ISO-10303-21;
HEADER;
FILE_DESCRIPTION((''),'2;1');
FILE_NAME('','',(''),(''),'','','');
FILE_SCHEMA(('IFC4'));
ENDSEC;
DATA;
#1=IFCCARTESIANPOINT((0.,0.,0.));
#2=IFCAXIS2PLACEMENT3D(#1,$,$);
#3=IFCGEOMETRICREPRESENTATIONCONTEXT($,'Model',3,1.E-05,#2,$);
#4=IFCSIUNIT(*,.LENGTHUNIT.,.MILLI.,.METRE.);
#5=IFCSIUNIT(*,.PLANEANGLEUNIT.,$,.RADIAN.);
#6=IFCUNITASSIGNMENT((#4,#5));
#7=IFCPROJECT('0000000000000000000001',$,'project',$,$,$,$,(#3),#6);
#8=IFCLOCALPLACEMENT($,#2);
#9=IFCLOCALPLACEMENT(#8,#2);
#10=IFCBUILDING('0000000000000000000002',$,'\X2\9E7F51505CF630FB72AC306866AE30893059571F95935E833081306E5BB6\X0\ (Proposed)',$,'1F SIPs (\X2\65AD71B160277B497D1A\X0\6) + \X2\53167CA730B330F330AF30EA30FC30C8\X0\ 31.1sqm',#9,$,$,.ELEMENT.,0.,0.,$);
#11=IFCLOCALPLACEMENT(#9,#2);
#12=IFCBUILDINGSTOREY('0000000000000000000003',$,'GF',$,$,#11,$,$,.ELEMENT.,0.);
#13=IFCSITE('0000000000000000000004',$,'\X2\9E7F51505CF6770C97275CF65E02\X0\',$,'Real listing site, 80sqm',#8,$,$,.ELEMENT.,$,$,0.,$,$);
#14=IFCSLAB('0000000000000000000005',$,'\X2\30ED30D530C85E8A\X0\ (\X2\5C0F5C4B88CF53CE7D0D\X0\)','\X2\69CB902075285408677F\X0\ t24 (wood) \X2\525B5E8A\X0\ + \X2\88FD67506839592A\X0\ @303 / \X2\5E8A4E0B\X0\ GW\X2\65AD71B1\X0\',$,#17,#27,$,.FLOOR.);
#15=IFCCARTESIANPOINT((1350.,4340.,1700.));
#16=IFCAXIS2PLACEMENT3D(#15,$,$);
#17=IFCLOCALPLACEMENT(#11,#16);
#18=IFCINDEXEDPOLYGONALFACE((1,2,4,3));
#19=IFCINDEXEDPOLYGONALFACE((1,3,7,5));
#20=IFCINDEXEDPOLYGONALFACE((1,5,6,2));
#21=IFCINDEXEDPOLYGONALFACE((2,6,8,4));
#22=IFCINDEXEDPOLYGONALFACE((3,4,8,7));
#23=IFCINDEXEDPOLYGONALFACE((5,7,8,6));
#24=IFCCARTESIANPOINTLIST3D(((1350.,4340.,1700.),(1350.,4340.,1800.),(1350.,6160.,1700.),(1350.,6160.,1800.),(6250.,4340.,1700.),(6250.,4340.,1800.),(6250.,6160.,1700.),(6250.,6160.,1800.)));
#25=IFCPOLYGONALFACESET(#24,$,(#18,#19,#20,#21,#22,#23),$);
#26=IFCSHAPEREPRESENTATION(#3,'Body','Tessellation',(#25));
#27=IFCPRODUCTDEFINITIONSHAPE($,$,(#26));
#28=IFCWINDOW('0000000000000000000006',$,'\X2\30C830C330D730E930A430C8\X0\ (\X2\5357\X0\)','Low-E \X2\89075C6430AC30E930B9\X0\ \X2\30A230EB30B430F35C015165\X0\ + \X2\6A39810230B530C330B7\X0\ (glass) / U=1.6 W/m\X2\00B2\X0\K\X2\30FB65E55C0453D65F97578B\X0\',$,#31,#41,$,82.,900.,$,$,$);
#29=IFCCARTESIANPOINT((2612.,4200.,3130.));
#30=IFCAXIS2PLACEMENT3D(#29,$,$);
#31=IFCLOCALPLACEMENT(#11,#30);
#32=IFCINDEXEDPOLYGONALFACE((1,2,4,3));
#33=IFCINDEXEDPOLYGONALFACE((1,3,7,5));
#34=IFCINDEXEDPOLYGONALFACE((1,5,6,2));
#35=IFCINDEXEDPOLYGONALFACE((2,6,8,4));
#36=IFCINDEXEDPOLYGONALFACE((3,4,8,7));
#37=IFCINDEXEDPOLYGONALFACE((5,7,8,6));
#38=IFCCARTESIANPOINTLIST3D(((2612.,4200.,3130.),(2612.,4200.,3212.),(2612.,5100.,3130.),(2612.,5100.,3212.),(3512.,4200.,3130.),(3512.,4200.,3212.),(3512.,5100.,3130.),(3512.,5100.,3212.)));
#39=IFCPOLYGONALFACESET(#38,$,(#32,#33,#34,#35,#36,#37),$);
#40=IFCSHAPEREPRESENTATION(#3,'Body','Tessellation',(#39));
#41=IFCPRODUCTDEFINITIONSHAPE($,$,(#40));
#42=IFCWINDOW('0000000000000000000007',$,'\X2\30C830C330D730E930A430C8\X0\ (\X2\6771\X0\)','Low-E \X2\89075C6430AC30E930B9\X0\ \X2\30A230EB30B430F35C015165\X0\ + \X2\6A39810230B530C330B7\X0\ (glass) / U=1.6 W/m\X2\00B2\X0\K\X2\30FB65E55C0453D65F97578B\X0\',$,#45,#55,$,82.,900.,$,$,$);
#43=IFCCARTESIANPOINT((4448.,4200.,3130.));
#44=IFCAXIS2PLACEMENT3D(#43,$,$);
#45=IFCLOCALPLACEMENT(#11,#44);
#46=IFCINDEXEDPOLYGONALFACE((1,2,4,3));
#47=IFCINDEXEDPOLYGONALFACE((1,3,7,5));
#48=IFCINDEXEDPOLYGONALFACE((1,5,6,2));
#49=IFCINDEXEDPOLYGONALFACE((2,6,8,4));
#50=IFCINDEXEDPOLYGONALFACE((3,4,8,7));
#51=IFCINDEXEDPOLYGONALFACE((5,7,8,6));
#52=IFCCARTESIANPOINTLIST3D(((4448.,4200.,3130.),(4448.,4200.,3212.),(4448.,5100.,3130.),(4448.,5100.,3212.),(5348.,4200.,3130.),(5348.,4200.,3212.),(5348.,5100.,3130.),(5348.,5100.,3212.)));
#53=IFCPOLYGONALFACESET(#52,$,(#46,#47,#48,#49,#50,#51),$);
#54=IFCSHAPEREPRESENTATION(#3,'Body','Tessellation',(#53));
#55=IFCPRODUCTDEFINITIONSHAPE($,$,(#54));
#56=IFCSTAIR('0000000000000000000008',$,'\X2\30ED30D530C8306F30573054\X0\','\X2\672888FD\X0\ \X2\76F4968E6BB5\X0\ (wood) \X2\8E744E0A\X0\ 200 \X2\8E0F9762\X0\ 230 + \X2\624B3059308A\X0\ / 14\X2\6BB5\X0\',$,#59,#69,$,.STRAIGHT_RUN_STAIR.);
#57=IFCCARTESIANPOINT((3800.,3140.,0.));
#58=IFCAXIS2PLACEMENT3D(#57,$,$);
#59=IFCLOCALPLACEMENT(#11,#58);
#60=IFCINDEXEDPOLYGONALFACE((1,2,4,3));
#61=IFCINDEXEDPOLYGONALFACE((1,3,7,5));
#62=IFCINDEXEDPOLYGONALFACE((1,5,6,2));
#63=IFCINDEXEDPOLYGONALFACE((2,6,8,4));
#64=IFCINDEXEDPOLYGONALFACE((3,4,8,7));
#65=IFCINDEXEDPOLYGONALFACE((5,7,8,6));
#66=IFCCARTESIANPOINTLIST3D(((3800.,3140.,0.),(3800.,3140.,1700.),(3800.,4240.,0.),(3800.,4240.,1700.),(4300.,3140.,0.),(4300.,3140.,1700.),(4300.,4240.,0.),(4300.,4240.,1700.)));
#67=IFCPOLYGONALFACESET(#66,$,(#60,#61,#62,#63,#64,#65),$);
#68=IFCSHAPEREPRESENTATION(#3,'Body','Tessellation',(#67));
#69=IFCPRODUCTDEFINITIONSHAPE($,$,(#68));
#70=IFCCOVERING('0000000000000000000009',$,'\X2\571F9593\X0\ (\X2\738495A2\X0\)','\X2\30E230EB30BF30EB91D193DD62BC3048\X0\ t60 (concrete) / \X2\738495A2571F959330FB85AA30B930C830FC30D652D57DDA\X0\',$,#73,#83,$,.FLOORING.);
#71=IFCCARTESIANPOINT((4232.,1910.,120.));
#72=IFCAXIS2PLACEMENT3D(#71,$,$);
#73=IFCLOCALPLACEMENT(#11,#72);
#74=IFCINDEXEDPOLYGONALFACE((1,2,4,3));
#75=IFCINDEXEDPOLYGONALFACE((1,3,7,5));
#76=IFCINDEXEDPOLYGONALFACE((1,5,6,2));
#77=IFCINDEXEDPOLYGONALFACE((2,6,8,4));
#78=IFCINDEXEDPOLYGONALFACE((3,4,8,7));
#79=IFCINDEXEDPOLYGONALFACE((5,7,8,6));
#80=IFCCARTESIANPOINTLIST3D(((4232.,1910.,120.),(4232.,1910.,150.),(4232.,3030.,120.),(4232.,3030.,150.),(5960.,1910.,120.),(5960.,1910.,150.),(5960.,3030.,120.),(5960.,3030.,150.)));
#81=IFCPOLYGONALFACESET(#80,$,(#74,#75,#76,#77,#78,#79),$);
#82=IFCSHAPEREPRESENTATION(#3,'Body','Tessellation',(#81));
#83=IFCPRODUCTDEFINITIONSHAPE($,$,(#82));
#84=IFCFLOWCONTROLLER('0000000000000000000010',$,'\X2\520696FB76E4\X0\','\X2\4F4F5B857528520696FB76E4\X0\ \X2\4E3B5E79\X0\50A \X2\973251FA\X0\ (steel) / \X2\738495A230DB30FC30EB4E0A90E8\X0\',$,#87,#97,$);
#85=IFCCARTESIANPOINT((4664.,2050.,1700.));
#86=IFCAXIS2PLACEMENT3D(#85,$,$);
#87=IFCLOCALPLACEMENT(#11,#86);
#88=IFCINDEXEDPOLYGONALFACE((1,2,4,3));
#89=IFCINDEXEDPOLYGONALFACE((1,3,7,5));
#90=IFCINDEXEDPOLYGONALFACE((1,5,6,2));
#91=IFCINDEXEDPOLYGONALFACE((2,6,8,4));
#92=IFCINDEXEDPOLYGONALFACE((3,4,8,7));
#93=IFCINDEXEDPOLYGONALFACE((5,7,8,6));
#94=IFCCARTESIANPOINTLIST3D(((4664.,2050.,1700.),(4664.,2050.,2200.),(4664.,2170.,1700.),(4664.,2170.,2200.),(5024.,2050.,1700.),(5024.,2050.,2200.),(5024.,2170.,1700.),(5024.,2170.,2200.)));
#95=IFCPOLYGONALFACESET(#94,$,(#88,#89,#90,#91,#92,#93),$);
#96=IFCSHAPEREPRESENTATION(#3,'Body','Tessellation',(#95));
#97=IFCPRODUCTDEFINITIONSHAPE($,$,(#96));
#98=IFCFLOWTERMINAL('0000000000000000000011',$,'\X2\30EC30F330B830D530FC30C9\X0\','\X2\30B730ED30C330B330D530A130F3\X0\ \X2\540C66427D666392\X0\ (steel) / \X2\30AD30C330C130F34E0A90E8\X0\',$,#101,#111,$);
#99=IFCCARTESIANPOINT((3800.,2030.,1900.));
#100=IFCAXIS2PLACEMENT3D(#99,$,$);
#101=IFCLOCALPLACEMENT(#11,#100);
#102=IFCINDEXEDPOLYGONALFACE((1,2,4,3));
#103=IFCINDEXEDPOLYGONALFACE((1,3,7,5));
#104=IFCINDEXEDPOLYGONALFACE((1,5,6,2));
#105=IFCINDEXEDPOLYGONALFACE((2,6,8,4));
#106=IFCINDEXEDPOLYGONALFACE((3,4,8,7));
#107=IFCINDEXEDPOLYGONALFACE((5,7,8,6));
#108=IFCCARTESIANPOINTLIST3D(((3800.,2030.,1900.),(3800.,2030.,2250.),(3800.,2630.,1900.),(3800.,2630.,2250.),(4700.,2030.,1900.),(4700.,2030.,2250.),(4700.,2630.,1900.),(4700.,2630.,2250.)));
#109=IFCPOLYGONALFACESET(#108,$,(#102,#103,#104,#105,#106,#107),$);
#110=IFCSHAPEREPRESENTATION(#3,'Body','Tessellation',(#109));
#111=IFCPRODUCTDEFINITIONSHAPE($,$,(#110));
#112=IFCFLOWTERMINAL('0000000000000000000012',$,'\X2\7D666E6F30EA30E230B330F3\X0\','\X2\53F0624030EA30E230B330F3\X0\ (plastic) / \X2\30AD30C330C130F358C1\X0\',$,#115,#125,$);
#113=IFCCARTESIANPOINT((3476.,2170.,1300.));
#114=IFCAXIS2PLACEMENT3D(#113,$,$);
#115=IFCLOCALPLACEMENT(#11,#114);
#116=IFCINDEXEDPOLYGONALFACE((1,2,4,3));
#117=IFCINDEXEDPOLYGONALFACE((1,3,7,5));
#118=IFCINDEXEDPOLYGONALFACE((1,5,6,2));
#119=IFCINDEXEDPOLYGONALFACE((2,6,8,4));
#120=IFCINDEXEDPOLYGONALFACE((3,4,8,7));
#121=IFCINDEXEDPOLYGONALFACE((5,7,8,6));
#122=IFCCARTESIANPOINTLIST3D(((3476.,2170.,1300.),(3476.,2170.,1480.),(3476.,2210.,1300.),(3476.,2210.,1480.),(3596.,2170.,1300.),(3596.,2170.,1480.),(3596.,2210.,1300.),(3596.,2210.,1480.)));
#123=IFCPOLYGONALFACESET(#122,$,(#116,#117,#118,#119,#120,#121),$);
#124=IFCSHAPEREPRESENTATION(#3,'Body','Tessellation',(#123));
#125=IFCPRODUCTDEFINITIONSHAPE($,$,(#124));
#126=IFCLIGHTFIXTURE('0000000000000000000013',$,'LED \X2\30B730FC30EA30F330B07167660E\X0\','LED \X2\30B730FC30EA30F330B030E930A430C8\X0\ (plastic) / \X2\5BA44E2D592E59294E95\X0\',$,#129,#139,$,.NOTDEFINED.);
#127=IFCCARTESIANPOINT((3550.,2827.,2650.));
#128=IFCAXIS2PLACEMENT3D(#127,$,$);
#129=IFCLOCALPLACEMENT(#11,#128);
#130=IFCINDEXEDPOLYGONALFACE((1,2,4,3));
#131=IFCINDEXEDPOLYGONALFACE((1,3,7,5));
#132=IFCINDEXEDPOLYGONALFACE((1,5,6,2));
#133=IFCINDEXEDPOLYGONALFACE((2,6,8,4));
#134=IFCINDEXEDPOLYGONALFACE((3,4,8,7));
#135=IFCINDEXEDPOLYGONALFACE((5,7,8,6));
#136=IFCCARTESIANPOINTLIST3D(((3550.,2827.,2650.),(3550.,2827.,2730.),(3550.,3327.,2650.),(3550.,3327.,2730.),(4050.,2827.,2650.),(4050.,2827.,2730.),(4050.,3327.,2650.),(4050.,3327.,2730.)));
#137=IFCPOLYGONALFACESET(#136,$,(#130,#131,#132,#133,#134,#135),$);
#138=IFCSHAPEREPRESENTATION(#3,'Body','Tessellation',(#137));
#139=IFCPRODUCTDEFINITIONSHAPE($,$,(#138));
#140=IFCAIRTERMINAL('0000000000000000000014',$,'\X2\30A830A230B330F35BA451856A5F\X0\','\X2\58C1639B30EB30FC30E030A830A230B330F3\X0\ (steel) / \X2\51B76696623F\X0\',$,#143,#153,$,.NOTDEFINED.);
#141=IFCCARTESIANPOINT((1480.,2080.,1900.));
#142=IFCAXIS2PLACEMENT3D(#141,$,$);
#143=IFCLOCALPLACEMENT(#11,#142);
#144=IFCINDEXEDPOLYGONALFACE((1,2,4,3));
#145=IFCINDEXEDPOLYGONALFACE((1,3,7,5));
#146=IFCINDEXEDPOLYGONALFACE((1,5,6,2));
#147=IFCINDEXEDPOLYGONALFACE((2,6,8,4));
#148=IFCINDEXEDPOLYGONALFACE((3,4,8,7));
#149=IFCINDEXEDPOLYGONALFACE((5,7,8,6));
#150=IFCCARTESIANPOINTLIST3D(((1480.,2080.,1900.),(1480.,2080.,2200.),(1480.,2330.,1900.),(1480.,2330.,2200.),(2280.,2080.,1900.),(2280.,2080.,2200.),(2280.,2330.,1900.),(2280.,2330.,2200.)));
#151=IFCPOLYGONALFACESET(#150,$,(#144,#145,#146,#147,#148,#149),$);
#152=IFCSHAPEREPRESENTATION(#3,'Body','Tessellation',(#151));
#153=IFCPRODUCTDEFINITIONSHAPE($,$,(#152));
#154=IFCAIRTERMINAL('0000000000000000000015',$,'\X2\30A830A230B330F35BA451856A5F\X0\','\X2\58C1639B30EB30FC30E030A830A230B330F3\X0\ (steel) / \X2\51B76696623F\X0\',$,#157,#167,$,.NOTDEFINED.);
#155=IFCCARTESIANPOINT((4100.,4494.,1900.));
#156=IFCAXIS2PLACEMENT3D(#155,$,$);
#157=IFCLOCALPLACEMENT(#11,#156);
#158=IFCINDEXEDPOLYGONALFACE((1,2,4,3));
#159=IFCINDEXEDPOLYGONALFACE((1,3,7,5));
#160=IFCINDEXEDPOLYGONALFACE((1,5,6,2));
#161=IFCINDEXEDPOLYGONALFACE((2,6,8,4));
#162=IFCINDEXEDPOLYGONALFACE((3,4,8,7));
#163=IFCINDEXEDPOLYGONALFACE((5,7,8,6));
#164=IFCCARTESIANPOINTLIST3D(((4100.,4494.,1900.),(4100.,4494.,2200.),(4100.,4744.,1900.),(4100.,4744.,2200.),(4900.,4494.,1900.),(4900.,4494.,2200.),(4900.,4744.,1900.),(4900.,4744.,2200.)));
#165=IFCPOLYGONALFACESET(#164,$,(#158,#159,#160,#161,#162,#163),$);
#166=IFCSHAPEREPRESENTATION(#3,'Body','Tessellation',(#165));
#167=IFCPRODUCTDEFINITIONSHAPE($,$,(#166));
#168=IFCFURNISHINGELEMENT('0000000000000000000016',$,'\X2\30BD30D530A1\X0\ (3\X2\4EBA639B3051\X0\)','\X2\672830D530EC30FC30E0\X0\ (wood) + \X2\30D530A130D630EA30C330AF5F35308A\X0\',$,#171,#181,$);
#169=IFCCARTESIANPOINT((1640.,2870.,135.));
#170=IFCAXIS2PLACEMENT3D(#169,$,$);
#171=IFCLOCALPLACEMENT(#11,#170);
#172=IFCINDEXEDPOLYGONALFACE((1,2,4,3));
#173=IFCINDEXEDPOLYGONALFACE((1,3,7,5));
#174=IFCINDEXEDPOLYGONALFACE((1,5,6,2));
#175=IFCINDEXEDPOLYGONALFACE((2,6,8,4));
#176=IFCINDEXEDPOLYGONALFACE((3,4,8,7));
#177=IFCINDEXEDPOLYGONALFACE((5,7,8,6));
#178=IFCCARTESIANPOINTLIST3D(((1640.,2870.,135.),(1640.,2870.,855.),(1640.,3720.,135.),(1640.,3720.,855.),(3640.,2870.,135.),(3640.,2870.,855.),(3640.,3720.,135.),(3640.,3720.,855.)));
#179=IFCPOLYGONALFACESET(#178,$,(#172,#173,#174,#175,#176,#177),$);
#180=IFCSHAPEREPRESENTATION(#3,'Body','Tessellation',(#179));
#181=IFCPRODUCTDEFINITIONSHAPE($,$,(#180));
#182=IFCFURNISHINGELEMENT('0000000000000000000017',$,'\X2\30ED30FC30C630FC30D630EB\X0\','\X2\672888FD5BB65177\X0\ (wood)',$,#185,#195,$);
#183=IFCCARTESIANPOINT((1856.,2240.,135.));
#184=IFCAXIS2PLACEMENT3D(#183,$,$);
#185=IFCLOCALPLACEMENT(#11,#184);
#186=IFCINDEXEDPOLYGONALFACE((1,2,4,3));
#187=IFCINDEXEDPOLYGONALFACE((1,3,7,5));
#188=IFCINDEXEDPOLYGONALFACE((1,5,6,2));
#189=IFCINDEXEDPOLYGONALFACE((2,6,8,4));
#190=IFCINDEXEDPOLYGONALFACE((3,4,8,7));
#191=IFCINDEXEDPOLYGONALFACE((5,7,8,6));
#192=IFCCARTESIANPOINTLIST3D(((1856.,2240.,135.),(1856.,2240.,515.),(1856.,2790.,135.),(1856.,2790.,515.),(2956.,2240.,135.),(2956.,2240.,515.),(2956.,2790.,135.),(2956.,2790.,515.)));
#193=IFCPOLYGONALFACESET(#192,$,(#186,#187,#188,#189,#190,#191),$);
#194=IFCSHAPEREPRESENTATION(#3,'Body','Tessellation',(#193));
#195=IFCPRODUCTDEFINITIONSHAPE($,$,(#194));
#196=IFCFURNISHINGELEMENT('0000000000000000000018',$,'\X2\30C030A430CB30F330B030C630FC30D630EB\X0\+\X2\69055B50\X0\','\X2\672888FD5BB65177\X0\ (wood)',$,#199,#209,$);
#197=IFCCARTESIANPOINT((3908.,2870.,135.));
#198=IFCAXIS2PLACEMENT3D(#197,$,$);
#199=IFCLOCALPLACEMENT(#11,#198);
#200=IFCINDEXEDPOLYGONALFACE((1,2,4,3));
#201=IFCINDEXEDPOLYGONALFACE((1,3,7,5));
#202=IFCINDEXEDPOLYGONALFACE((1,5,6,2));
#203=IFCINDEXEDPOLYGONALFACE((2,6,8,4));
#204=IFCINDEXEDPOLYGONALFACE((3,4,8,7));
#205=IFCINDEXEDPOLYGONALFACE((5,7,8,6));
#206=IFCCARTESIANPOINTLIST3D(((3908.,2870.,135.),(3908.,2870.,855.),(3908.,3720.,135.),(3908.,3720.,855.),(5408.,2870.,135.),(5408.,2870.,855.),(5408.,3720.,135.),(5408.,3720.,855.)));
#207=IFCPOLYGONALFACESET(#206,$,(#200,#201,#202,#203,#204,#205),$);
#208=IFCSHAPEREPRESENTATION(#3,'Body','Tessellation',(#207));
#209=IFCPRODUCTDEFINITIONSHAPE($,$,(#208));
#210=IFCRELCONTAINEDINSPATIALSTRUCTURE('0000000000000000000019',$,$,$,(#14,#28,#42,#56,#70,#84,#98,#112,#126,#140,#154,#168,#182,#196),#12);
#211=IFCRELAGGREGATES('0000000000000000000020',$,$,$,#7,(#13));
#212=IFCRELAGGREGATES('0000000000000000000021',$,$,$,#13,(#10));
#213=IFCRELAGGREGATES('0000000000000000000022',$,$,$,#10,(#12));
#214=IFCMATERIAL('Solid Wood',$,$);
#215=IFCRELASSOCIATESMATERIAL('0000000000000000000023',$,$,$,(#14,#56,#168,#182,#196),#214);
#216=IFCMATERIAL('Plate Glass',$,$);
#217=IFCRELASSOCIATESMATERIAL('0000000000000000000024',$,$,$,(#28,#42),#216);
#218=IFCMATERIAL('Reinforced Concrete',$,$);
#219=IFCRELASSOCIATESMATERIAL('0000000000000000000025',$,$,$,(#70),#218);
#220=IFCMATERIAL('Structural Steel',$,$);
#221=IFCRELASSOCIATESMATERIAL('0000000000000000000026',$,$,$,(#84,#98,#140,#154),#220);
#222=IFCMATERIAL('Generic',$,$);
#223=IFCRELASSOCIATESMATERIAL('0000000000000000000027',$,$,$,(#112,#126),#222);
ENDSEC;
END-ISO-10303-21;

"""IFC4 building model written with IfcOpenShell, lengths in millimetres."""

from ifc_helpers import new_model, si_unit, frame, frame_2d, origin, place, context, project, spatial, rectangle, extrude, material, element, save


model = new_model("IFC4")

# Units and contexts
model_context = context("Model", 3, precision=1e-05, world=origin())
ifc_project = project(units=[si_unit("LENGTHUNIT", "METRE", prefix="MILLI"), si_unit("PLANEANGLEUNIT", "RADIAN")], contexts=[model_context])

# Site, building, storey
site_placement = place(None, origin())
site = spatial("IfcSite", under=ifc_project, at=site_placement, Name="鹿児島県霧島市", ObjectType="Real listing site, 80sqm", CompositionType="ELEMENT", RefElevation=0.0)
building_placement = place(site_placement, origin())
building = spatial("IfcBuilding", under=site, at=building_placement, Name="鹿児島・犬と暮らす土間広めの家 (Proposed)", ObjectType="1F SIPs (断熱性等級6) + 化粧コンクリート 31.1sqm", CompositionType="ELEMENT", ElevationOfRefHeight=0.0, ElevationOfTerrain=0.0)
storey_placement = place(building_placement, origin())
storey = spatial("IfcBuildingStorey", under=building, at=storey_placement, Name="GF", CompositionType="ELEMENT", Elevation=0.0)

# Shared definitions
ifc_material_1 = material(Name="Solid Wood")

# Slab
slab_placement = place(storey_placement, frame((1350.0, 4340.0, 1700.0)))
element("IfcSlab", 1, at=slab_placement, inside=storey, material=ifc_material_1, Name="ロフト床 (小屋裏収納)", Description="構造用合板 t24 (wood) 剛床 + 製材根太 @303 / 床下 GW断熱", PredefinedType="FLOOR", context=model_context, shape_type="SweptSolid", body=[
    extrude(rectangle(XDim=4900.0, YDim=1820.0, at=frame_2d((2450.0, 910.0))), frame((1350.0, 4340.0, 1700.0)), (0.0, 0.0, 1.0), 100.0),
])

# Windows
ifc_material_2 = material(Name="Plate Glass")
window_1_placement = place(storey_placement, frame((2612.0, 4200.0, 3130.0)))
element("IfcWindow", 2, at=window_1_placement, inside=storey, material=ifc_material_2, Name="トップライト (南)", Description="Low-E 複層ガラス アルゴン封入 + 樹脂サッシ (glass) / U=1.6 W/m²K・日射取得型", OverallHeight=82.0, OverallWidth=900.0, context=model_context, shape_type="SweptSolid", body=[
    extrude(rectangle(XDim=900.0, YDim=900.0, at=frame_2d((450.0, 450.0))), frame((2612.0, 4200.0, 3130.0)), (0.0, 0.0, 1.0), 82.0),
])
window_2_placement = place(storey_placement, frame((4448.0, 4200.0, 3130.0)))
element("IfcWindow", 3, at=window_2_placement, inside=storey, material=ifc_material_2, Name="トップライト (東)", Description="Low-E 複層ガラス アルゴン封入 + 樹脂サッシ (glass) / U=1.6 W/m²K・日射取得型", OverallHeight=82.0, OverallWidth=900.0, context=model_context, shape_type="SweptSolid", body=[
    extrude(rectangle(XDim=900.0, YDim=900.0, at=frame_2d((450.0, 450.0))), frame((4448.0, 4200.0, 3130.0)), (0.0, 0.0, 1.0), 82.0),
])

# Stair
stair_placement = place(storey_placement, frame((3800.0, 3140.0, 0.0)))
element("IfcStair", 4, at=stair_placement, inside=storey, material=ifc_material_1, Name="ロフトはしご", Description="木製 直階段 (wood) 蹴上 200 踏面 230 + 手すり / 14段", PredefinedType="STRAIGHT_RUN_STAIR", context=model_context, shape_type="SweptSolid", body=[
    extrude(rectangle(XDim=500.0, YDim=1100.0, at=frame_2d((250.0, 550.0))), frame((3800.0, 3140.0, 0.0)), (0.0, 0.0, 1.0), 1700.0),
])

# Covering
ifc_material_3 = material(Name="Reinforced Concrete")
covering_placement = place(storey_placement, frame((4232.0, 1910.0, 120.0)))
element("IfcCovering", 5, at=covering_placement, inside=storey, material=ifc_material_3, Name="土間 (玄関)", Description="モルタル金鏝押え t60 (concrete) / 玄関土間・薪ストーブ動線", PredefinedType="FLOORING", context=model_context, shape_type="SweptSolid", body=[
    extrude(rectangle(XDim=1728.0, YDim=1120.0, at=frame_2d((864.0, 560.0))), frame((4232.0, 1910.0, 120.0)), (0.0, 0.0, 1.0), 30.0),
])

# Flow controller
ifc_material_4 = material(Name="Structural Steel")
flow_controller_placement = place(storey_placement, frame((4664.0, 2050.0, 1700.0)))
element("IfcFlowController", 6, at=flow_controller_placement, inside=storey, material=ifc_material_4, Name="分電盤", Description="住宅用分電盤 主幹50A 露出 (steel) / 玄関ホール上部", context=model_context, shape_type="SweptSolid", body=[
    extrude(rectangle(XDim=360.0, YDim=120.0, at=frame_2d((180.0, 60.0))), frame((4664.0, 2050.0, 1700.0)), (0.0, 0.0, 1.0), 500.0),
])

# Flow terminals
flow_terminal_1_placement = place(storey_placement, frame((3800.0, 2030.0, 1900.0)))
element("IfcFlowTerminal", 7, at=flow_terminal_1_placement, inside=storey, material=ifc_material_4, Name="レンジフード", Description="シロッコファン 同時給排 (steel) / キッチン上部", context=model_context, shape_type="SweptSolid", body=[
    extrude(rectangle(XDim=900.0, YDim=600.0, at=frame_2d((450.0, 300.0))), frame((3800.0, 2030.0, 1900.0)), (0.0, 0.0, 1.0), 350.0),
])
ifc_material_5 = material(Name="Generic")
flow_terminal_2_placement = place(storey_placement, frame((3476.0, 2170.0, 1300.0)))
element("IfcFlowTerminal", 8, at=flow_terminal_2_placement, inside=storey, material=ifc_material_5, Name="給湯リモコン", Description="台所リモコン (plastic) / キッチン壁", context=model_context, shape_type="SweptSolid", body=[
    extrude(rectangle(XDim=120.0, YDim=40.0, at=frame_2d((60.0, 20.0))), frame((3476.0, 2170.0, 1300.0)), (0.0, 0.0, 1.0), 180.0),
])

# Light fixture
light_fixture_placement = place(storey_placement, frame((3550.0, 2827.0, 2650.0)))
element("IfcLightFixture", 9, at=light_fixture_placement, inside=storey, material=ifc_material_5, Name="LED シーリング照明", Description="LED シーリングライト (plastic) / 室中央天井", PredefinedType="NOTDEFINED", context=model_context, shape_type="SweptSolid", body=[
    extrude(rectangle(XDim=500.0, YDim=500.0, at=frame_2d((250.0, 250.0))), frame((3550.0, 2827.0, 2650.0)), (0.0, 0.0, 1.0), 80.0),
])

# Air terminals
air_terminal_1_placement = place(storey_placement, frame((1480.0, 2080.0, 1900.0)))
element("IfcAirTerminal", 10, at=air_terminal_1_placement, inside=storey, material=ifc_material_4, Name="エアコン室内機", Description="壁掛ルームエアコン (steel) / 冷暖房", PredefinedType="NOTDEFINED", context=model_context, shape_type="SweptSolid", body=[
    extrude(rectangle(XDim=800.0, YDim=250.0, at=frame_2d((400.0, 125.0))), frame((1480.0, 2080.0, 1900.0)), (0.0, 0.0, 1.0), 300.0),
])
air_terminal_2_placement = place(storey_placement, frame((4100.0, 4494.0, 1900.0)))
element("IfcAirTerminal", 11, at=air_terminal_2_placement, inside=storey, material=ifc_material_4, Name="エアコン室内機", Description="壁掛ルームエアコン (steel) / 冷暖房", PredefinedType="NOTDEFINED", context=model_context, shape_type="SweptSolid", body=[
    extrude(rectangle(XDim=800.0, YDim=250.0, at=frame_2d((400.0, 125.0))), frame((4100.0, 4494.0, 1900.0)), (0.0, 0.0, 1.0), 300.0),
])

# Furnishing elements
furnishing_1_placement = place(storey_placement, frame((1640.0, 2870.0, 135.0)))
element("IfcFurnishingElement", 12, at=furnishing_1_placement, inside=storey, material=ifc_material_1, Name="ソファ (3人掛け)", Description="木フレーム (wood) + ファブリック張り", context=model_context, shape_type="SweptSolid", body=[
    extrude(rectangle(XDim=2000.0, YDim=850.0, at=frame_2d((1000.0, 425.0))), frame((1640.0, 2870.0, 135.0)), (0.0, 0.0, 1.0), 720.0),
])
furnishing_2_placement = place(storey_placement, frame((1856.0, 2240.0, 135.0)))
element("IfcFurnishingElement", 13, at=furnishing_2_placement, inside=storey, material=ifc_material_1, Name="ローテーブル", Description="木製家具 (wood)", context=model_context, shape_type="SweptSolid", body=[
    extrude(rectangle(XDim=1100.0, YDim=550.0, at=frame_2d((550.0, 275.0))), frame((1856.0, 2240.0, 135.0)), (0.0, 0.0, 1.0), 380.0),
])
furnishing_3_placement = place(storey_placement, frame((3908.0, 2870.0, 135.0)))
element("IfcFurnishingElement", 14, at=furnishing_3_placement, inside=storey, material=ifc_material_1, Name="ダイニングテーブル+椅子", Description="木製家具 (wood)", context=model_context, shape_type="SweptSolid", body=[
    extrude(rectangle(XDim=1500.0, YDim=850.0, at=frame_2d((750.0, 425.0))), frame((3908.0, 2870.0, 135.0)), (0.0, 0.0, 1.0), 720.0),
])

save(model, "model.ifc")
